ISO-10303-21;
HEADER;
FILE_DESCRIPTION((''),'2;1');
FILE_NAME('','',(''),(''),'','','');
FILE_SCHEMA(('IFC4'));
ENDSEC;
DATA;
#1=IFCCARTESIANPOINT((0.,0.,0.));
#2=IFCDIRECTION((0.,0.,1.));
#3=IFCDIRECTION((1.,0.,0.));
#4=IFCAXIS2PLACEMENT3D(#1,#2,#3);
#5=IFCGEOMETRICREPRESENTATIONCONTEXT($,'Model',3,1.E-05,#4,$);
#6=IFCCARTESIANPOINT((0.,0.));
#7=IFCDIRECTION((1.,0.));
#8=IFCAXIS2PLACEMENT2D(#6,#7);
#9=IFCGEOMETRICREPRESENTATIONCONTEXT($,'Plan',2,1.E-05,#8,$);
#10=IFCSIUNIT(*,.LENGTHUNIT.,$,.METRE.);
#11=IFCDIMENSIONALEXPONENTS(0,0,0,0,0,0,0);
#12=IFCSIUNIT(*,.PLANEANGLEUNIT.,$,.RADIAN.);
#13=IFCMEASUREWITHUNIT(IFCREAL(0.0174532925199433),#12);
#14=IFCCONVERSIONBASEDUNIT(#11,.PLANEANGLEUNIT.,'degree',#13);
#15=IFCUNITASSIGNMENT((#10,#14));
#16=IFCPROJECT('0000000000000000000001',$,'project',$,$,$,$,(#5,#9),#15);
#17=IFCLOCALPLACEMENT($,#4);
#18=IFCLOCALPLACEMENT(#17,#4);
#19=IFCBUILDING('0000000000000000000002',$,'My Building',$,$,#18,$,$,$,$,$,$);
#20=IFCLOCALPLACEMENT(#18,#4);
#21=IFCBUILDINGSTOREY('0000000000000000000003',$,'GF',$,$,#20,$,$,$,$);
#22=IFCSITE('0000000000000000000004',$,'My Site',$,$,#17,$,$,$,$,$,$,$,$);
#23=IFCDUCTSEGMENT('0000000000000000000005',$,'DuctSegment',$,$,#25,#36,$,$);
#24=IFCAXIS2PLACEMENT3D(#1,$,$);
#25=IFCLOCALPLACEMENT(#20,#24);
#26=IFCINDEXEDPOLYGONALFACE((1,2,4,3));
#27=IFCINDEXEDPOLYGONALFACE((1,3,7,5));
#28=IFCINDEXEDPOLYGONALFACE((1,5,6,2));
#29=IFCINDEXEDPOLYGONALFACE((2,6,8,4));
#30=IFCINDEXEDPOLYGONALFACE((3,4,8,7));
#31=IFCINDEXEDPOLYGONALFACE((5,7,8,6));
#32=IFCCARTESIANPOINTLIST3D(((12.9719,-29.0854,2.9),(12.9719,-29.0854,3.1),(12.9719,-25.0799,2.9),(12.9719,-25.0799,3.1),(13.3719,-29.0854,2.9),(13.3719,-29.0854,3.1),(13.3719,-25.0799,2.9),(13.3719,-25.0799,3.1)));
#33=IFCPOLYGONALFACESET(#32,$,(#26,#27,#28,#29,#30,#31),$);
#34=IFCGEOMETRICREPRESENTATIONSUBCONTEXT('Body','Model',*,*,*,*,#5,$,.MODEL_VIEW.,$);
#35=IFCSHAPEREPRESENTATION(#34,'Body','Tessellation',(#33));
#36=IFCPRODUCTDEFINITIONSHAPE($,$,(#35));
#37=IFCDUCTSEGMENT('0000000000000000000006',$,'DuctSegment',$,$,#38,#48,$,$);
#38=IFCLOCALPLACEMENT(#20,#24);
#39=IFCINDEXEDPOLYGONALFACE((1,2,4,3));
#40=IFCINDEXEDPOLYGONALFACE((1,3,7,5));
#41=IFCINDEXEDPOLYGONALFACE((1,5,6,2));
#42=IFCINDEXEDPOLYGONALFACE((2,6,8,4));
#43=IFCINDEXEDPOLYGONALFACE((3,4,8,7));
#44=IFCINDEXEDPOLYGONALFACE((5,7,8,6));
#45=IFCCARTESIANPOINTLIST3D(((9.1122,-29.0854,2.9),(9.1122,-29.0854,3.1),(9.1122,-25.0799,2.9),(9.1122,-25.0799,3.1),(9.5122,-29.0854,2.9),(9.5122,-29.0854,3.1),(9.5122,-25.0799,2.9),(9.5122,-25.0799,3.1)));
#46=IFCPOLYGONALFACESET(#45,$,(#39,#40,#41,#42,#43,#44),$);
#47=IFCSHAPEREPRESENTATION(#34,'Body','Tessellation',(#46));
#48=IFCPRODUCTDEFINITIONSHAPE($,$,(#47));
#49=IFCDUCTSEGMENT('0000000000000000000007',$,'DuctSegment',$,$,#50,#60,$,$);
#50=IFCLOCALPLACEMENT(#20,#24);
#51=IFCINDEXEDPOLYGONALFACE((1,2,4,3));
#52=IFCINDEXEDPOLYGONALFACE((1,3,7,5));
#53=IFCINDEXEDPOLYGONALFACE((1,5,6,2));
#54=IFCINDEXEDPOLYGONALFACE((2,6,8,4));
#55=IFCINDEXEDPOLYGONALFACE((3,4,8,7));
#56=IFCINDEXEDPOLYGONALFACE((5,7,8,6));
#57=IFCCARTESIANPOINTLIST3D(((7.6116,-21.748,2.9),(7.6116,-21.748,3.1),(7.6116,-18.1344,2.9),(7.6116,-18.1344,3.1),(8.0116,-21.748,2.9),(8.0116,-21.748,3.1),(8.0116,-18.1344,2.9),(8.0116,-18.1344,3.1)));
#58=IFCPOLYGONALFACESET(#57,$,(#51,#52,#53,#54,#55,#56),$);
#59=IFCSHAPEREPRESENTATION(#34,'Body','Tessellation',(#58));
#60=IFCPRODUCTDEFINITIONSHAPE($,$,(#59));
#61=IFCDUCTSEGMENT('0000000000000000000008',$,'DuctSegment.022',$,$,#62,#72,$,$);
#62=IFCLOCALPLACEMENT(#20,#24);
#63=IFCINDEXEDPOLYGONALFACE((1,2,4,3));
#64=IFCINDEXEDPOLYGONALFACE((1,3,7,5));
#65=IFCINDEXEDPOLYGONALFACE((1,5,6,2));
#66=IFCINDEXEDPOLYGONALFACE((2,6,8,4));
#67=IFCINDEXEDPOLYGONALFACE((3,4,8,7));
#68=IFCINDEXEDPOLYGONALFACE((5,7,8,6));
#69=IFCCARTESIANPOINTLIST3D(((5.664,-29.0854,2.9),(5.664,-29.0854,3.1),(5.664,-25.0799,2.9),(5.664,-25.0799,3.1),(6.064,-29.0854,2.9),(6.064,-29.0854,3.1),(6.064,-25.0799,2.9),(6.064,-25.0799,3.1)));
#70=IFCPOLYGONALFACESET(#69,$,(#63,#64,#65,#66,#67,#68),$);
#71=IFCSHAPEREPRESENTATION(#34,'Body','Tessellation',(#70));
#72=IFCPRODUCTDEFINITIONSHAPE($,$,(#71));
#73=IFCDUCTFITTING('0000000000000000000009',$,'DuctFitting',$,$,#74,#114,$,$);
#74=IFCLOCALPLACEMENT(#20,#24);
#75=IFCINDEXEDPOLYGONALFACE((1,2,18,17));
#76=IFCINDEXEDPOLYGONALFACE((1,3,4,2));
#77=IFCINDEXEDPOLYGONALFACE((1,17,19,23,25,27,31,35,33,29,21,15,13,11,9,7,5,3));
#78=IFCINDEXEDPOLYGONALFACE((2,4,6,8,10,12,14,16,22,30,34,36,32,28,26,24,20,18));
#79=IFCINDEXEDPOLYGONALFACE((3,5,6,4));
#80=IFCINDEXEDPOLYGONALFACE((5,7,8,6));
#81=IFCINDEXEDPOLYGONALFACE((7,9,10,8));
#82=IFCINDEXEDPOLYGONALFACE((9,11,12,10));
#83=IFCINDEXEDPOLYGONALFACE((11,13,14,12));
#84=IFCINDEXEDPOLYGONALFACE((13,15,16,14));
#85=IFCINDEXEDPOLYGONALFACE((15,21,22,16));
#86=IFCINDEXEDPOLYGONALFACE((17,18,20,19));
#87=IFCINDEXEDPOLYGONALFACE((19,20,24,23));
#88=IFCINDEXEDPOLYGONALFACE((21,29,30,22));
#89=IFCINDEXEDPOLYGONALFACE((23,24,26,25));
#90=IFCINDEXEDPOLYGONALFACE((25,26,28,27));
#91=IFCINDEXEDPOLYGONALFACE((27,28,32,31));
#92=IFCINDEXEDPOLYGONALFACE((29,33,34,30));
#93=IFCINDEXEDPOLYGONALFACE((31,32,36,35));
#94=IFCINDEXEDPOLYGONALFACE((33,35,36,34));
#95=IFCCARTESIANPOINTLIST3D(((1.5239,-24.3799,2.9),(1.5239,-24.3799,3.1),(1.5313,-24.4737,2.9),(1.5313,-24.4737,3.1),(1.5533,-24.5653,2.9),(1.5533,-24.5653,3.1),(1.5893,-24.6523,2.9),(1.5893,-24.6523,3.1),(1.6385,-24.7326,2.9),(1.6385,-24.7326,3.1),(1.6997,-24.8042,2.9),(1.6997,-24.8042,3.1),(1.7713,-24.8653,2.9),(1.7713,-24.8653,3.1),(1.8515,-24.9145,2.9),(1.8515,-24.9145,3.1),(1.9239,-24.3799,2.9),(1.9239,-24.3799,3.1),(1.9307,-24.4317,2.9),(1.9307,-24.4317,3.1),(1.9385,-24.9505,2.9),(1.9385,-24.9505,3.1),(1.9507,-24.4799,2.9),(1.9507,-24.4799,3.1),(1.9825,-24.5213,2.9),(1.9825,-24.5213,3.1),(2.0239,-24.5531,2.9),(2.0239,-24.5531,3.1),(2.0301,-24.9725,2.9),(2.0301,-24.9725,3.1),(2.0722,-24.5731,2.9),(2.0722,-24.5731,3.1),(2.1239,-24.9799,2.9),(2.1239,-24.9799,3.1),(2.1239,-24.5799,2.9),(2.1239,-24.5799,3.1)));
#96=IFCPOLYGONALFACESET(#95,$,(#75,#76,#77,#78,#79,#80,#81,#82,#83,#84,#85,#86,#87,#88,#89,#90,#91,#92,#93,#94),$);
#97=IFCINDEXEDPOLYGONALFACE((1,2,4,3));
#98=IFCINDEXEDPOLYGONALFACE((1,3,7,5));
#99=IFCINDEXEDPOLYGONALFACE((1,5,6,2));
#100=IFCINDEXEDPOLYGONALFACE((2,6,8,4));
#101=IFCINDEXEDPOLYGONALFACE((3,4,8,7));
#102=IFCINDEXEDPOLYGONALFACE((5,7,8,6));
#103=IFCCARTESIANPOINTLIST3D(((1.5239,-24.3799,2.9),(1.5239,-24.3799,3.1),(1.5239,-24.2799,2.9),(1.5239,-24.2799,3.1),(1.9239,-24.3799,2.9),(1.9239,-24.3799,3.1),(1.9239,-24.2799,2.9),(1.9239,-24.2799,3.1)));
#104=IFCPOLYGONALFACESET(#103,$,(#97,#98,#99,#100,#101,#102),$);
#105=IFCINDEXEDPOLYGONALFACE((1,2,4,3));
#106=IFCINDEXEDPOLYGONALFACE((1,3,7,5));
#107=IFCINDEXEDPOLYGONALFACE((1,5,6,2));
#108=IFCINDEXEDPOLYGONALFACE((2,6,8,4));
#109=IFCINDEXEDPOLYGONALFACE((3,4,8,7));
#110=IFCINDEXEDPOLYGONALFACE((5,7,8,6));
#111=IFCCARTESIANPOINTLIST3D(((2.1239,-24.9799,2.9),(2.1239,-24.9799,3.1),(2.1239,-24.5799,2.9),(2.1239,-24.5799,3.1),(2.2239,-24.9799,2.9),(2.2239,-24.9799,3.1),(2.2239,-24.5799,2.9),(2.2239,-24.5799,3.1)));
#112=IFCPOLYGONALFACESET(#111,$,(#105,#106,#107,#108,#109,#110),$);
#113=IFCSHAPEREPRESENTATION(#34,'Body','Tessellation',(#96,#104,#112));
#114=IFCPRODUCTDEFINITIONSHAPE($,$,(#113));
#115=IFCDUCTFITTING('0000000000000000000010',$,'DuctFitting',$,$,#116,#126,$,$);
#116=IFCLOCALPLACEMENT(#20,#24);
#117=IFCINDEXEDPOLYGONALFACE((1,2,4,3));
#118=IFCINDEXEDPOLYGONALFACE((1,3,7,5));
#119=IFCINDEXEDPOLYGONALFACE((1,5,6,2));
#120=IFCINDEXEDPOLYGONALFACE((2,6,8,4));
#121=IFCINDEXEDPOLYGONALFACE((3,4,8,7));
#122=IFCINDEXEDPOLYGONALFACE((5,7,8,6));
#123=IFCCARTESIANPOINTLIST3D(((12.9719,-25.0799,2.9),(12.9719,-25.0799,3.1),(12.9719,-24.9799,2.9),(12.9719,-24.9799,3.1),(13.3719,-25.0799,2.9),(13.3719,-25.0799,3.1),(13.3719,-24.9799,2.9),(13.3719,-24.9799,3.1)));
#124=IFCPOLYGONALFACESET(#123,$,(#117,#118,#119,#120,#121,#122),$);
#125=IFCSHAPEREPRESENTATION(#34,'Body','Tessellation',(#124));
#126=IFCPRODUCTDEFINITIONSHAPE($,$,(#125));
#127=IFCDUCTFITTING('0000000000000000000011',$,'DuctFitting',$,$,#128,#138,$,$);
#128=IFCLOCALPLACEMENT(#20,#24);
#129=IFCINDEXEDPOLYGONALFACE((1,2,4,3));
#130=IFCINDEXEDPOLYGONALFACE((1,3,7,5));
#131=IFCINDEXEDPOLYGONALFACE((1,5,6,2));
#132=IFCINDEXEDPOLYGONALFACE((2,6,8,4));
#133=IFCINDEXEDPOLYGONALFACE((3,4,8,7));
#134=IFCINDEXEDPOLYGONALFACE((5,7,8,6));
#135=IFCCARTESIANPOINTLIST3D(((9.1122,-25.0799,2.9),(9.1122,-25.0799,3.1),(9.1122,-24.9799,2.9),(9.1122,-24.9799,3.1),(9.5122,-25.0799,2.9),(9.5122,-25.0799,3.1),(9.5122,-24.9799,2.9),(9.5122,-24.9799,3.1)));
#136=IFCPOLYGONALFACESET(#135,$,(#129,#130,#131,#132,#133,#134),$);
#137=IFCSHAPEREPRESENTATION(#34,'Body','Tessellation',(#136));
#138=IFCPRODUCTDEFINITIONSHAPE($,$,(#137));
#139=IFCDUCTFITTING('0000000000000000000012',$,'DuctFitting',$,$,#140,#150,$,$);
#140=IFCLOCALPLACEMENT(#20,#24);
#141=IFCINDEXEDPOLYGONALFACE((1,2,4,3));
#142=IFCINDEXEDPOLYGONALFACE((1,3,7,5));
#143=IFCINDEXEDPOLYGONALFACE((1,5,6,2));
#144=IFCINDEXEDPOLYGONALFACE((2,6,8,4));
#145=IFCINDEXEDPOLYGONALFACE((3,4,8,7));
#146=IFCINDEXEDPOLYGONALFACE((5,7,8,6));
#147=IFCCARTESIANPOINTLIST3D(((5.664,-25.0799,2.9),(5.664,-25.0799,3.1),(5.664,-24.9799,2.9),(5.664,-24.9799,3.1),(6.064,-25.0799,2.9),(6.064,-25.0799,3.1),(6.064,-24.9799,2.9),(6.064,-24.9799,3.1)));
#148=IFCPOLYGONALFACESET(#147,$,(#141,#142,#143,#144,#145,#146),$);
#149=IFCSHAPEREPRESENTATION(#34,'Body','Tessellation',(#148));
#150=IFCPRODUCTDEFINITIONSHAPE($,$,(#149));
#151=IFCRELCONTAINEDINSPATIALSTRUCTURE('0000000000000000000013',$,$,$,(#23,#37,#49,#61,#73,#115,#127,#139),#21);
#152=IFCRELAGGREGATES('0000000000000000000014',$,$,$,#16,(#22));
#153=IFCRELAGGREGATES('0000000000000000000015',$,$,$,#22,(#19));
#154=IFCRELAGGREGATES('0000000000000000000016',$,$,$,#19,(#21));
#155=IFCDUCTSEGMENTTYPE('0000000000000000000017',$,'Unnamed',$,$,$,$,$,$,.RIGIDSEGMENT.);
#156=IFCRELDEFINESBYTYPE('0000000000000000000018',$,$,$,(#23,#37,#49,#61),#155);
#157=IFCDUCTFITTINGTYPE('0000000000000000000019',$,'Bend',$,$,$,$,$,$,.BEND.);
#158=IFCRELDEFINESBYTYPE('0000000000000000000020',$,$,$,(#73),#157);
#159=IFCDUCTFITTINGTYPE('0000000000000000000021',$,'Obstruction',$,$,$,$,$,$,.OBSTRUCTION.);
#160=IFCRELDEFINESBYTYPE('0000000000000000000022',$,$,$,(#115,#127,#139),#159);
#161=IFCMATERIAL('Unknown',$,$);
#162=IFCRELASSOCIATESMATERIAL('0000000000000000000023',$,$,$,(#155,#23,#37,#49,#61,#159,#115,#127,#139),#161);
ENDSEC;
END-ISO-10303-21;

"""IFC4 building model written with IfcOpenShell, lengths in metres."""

from ifc_helpers import new_model, entity, si_unit, converted_unit, frame, origin_with_axes, origin_2d_with_axis, place, context, subcontext, project, spatial, line, arc, indexed_curve, rectangle, outline, extrude, source, transform, mapped, material, material_profile, profile_set, profile_usage, type_object, type_shapes, element, save


model = new_model("IFC4")

# Units and contexts
model_context = context("Model", 3, precision=1e-05, world=origin_with_axes())
plan_context = context("Plan", 2, precision=1e-05, world=origin_2d_with_axis())
body_context_1 = subcontext(model_context, "Body", "Model", "MODEL_VIEW")
ifc_project = project(units=[si_unit("LENGTHUNIT", "METRE"), converted_unit("PLANEANGLEUNIT", "degree", entity("IfcReal", 0.0174532925199433), si_unit("PLANEANGLEUNIT", "RADIAN"), dimensions=[0, 0, 0, 0, 0, 0, 0])], contexts=[model_context, plan_context])

# Site, building, storey
site_placement = place(None, origin_with_axes())
site = spatial("IfcSite", under=ifc_project, at=site_placement, Name="My Site")
building_placement = place(site_placement, origin_with_axes())
building = spatial("IfcBuilding", under=site, at=building_placement, Name="My Building")
storey_placement = place(building_placement, origin_with_axes())
storey = spatial("IfcBuildingStorey", under=building, at=storey_placement, Name="GF")

# Shared definitions
ifc_material = material(Name="Unknown")

# Duct segments
ifc_material_profile_1 = material_profile(ifc_material, rectangle(XDim=0.4, YDim=0.2))
ifc_profile_set_1 = profile_set([ifc_material_profile_1])
duct_segment_type = type_object("IfcDuctSegmentType", Name="Unnamed", PredefinedType="RIGIDSEGMENT", material=ifc_profile_set_1)
ifc_profile_usage_1 = profile_usage(ifc_profile_set_1, cardinal=5)
duct_segment_1_placement = place(storey_placement, frame((13.1719, -25.0799, 3.0), z_axis=(0.0, -1.0, 0.0), x_axis=(1.0, 0.0, 0.0)))
element("IfcDuctSegment", 1, at=duct_segment_1_placement, inside=storey, type_object=duct_segment_type, material=ifc_profile_usage_1, Name="DuctSegment", context=body_context_1, shape_type="SweptSolid", body=[
    extrude(rectangle(XDim=0.4, YDim=0.2), origin_with_axes(), (0.0, 0.0, 1.0), 4.0055),
])
ifc_profile_usage_2 = profile_usage(ifc_profile_set_1, cardinal=5)
duct_segment_2_placement = place(storey_placement, frame((9.3122, -25.0799, 3.0), z_axis=(0.0, -1.0, 0.0), x_axis=(1.0, 0.0, 0.0)))
element("IfcDuctSegment", 2, at=duct_segment_2_placement, inside=storey, type_object=duct_segment_type, material=ifc_profile_usage_2, Name="DuctSegment", context=body_context_1, shape_type="SweptSolid", body=[
    extrude(rectangle(XDim=0.4, YDim=0.2), origin_with_axes(), (0.0, 0.0, 1.0), 4.0055),
])
ifc_profile_usage_3 = profile_usage(ifc_profile_set_1, cardinal=5)
duct_segment_3_placement = place(storey_placement, frame((7.8116, -18.1344, 3.0), z_axis=(0.0, -1.0, 0.0), x_axis=(1.0, 0.0, 0.0)))
element("IfcDuctSegment", 3, at=duct_segment_3_placement, inside=storey, type_object=duct_segment_type, material=ifc_profile_usage_3, Name="DuctSegment", context=body_context_1, shape_type="SweptSolid", body=[
    extrude(rectangle(XDim=0.4, YDim=0.2), origin_with_axes(), (0.0, 0.0, 1.0), 3.6136),
])
ifc_profile_usage_4 = profile_usage(ifc_profile_set_1, cardinal=5)
duct_segment_4_placement = place(storey_placement, frame((5.864, -25.0799, 3.0), z_axis=(0.0, -1.0, 0.0), x_axis=(1.0, 0.0, 0.0)))
element("IfcDuctSegment", 4, at=duct_segment_4_placement, inside=storey, type_object=duct_segment_type, material=ifc_profile_usage_4, Name="DuctSegment.022", context=body_context_1, shape_type="SweptSolid", body=[
    extrude(rectangle(XDim=0.4, YDim=0.2), origin_with_axes(), (0.0, 0.0, 1.0), 4.0055),
])

# Duct fittings
duct_fitting_type_1 = type_object("IfcDuctFittingType", Name="Bend", PredefinedType="BEND")
shared_shape_1 = source(origin_with_axes(), body_context_1, "Body", "SweptSolid", [
    extrude(outline(indexed_curve([(-0.2, 0.0), (-0.2586, -0.1414), (-0.4, -0.2), (-0.4, -0.6), (0.0243, -0.4243), (0.2, 0.0)], segments=[arc(1, 2, 3), line(3, 4), arc(4, 5, 6), line(6, 1)])), frame((0.0, -0.1, -0.1), z_axis=(0.0, -1.0, 0.0), x_axis=(1.0, 0.0, 0.0)), (0.0, 0.0, -1.0), 0.2),
    extrude(rectangle(XDim=0.4, YDim=0.2), origin_with_axes(), (0.0, 0.0, -1.0), 0.1),
    extrude(rectangle(XDim=0.4, YDim=0.2), frame((-0.4, 0.0, -0.5), z_axis=(-1.0, 0.0, 0.0), x_axis=(0.0, 0.0, -1.0)), (0.0, 0.0, 1.0), 0.1),
])
type_shapes(duct_fitting_type_1, [shared_shape_1])
duct_fitting_1_placement = place(storey_placement, frame((1.7239, -24.2799, 3.0), z_axis=(0.0, 1.0, 0.0), x_axis=(-1.0, 0.0, 0.0)))
element("IfcDuctFitting", 5, at=duct_fitting_1_placement, inside=storey, type_object=duct_fitting_type_1, Name="DuctFitting", context=body_context_1, shape_type="MappedRepresentation", body=[
    mapped(shared_shape_1, transform((0.0, 0.0, 0.0), x_axis=(1.0, 0.0, 0.0), y_axis=(0.0, 1.0, 0.0), z_axis=(0.0, 0.0, 1.0), scale=1.0)),
])
ifc_material_profile_2 = material_profile(ifc_material, rectangle(XDim=0.4, YDim=0.2))
ifc_profile_set_2 = profile_set([ifc_material_profile_2])
ifc_profile_usage_5 = profile_usage(ifc_profile_set_2, cardinal=5)
duct_fitting_type_2 = type_object("IfcDuctFittingType", Name="Obstruction", PredefinedType="OBSTRUCTION", material=ifc_profile_set_2)
duct_fitting_2_placement = place(storey_placement, frame((13.1719, -24.9799, 3.0), z_axis=(0.0, -1.0, 0.0), x_axis=(1.0, 0.0, 0.0)))
element("IfcDuctFitting", 6, at=duct_fitting_2_placement, inside=storey, type_object=duct_fitting_type_2, material=ifc_profile_usage_5, Name="DuctFitting", context=body_context_1, shape_type="SweptSolid", body=[
    extrude(rectangle(XDim=0.4, YDim=0.2), origin_with_axes(), (0.0, 0.0, 1.0), 0.1),
])
ifc_profile_usage_6 = profile_usage(ifc_profile_set_2, cardinal=5)
duct_fitting_3_placement = place(storey_placement, frame((9.3122, -24.9799, 3.0), z_axis=(0.0, -1.0, 0.0), x_axis=(1.0, 0.0, 0.0)))
element("IfcDuctFitting", 7, at=duct_fitting_3_placement, inside=storey, type_object=duct_fitting_type_2, material=ifc_profile_usage_6, Name="DuctFitting", context=body_context_1, shape_type="SweptSolid", body=[
    extrude(rectangle(XDim=0.4, YDim=0.2), origin_with_axes(), (0.0, 0.0, 1.0), 0.1),
])
ifc_profile_usage_7 = profile_usage(ifc_profile_set_2, cardinal=5)
duct_fitting_4_placement = place(storey_placement, frame((5.864, -24.9799, 3.0), z_axis=(0.0, -1.0, 0.0), x_axis=(1.0, 0.0, 0.0)))
element("IfcDuctFitting", 8, at=duct_fitting_4_placement, inside=storey, type_object=duct_fitting_type_2, material=ifc_profile_usage_7, Name="DuctFitting", context=body_context_1, shape_type="SweptSolid", body=[
    extrude(rectangle(XDim=0.4, YDim=0.2), origin_with_axes(), (0.0, 0.0, 1.0), 0.1),
])

save(model, "model.ifc")
